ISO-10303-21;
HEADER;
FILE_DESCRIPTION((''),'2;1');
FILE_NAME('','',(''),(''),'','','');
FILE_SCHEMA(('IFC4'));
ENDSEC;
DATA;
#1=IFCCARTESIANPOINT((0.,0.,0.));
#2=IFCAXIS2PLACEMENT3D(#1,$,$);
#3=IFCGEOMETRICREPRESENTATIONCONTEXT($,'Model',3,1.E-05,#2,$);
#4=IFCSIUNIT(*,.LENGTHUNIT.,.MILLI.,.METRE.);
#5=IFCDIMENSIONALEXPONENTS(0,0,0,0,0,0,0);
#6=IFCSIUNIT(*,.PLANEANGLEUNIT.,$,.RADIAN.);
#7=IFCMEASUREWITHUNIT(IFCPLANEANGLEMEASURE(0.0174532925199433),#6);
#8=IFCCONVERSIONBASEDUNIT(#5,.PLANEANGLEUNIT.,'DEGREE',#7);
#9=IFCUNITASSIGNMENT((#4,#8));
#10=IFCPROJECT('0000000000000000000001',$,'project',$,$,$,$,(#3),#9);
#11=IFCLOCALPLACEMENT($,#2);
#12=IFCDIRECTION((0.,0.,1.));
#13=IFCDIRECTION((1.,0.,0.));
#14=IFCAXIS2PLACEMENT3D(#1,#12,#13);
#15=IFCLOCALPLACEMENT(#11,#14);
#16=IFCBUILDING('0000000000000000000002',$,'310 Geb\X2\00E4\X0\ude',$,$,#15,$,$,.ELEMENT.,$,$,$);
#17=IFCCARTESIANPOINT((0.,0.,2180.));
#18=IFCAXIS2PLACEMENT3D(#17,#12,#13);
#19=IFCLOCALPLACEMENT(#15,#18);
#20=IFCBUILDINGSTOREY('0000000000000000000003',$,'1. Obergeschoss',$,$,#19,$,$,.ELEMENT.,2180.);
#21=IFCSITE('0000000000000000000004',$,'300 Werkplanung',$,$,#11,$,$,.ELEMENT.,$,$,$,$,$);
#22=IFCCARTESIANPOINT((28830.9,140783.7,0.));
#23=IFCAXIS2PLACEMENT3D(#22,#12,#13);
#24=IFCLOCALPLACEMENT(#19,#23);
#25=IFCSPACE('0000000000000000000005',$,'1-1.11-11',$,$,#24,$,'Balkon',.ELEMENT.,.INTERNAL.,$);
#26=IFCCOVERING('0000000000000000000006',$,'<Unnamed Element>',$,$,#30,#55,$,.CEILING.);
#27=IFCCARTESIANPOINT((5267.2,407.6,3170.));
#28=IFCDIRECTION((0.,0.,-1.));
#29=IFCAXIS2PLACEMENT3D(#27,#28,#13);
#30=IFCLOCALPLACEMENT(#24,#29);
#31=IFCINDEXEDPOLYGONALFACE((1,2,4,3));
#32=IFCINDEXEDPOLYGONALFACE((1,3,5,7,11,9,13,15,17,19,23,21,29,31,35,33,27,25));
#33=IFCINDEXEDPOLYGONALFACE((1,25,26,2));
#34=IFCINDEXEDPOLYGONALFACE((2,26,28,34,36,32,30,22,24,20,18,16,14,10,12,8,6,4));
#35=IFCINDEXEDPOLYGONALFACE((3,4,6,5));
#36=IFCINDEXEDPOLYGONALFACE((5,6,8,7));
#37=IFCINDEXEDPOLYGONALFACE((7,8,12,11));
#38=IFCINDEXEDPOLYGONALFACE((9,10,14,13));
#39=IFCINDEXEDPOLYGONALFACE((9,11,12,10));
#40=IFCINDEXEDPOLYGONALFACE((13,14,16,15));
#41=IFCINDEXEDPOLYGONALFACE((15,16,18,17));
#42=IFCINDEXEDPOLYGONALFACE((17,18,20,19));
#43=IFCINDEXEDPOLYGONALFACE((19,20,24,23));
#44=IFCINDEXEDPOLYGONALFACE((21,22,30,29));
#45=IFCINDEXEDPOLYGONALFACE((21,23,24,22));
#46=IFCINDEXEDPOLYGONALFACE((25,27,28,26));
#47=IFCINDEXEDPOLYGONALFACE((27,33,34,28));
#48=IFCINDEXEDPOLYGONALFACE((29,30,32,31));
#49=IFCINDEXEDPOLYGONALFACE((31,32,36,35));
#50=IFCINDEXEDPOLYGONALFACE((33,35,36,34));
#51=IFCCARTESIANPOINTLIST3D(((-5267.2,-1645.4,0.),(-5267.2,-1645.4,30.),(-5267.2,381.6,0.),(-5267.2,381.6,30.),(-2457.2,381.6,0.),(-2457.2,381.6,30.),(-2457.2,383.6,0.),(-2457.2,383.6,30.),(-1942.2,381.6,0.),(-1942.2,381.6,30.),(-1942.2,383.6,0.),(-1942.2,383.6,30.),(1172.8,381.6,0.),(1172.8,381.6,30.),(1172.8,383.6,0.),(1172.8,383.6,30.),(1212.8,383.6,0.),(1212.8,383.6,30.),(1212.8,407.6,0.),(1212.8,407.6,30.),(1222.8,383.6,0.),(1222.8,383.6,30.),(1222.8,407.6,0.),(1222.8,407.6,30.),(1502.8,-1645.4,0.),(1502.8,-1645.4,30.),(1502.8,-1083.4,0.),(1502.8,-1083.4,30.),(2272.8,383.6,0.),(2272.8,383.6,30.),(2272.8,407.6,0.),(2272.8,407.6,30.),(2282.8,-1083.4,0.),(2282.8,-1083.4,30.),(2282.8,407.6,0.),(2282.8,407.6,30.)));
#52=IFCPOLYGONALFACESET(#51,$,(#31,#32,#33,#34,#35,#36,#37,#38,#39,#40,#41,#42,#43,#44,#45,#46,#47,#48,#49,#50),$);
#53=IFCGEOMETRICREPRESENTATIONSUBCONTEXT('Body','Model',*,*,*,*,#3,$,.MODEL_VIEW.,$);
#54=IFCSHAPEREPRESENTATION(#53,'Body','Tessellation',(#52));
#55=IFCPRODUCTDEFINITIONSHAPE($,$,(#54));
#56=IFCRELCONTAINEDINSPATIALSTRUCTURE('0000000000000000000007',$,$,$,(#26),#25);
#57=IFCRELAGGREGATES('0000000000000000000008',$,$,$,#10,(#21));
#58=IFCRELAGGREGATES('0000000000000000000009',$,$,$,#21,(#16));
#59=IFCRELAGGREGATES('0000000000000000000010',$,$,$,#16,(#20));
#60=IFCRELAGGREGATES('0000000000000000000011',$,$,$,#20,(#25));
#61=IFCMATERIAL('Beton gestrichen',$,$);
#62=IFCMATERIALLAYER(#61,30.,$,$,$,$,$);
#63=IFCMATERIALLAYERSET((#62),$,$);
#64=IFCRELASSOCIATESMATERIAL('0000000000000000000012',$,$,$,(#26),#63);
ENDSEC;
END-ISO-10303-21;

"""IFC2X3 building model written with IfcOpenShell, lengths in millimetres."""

from ifc_helpers import new_model, entity, si_unit, converted_unit, frame, origin, origin_with_axes, place, context, subcontext, project, spatial, polyline, outline, extrude, material, layer, layer_set, layer_usage, element, save


model = new_model("IFC2X3")

# Units and contexts
model_context = context("Model", 3, precision=1e-05, world=origin())
body_context = subcontext(model_context, "Body", "Model", "MODEL_VIEW")
ifc_project = project(units=[si_unit("LENGTHUNIT", "METRE", prefix="MILLI"), converted_unit("PLANEANGLEUNIT", "DEGREE", entity("IfcPlaneAngleMeasure", 0.0174532925199433), si_unit("PLANEANGLEUNIT", "RADIAN"), dimensions=[0, 0, 0, 0, 0, 0, 0])], contexts=[model_context])

# Site, building, storey
site_placement = place(None, origin())
site = spatial("IfcSite", under=ifc_project, at=site_placement, Name="300 Werkplanung", CompositionType="ELEMENT")
building_placement = place(site_placement, origin_with_axes())
building = spatial("IfcBuilding", under=site, at=building_placement, Name="310 Gebäude", CompositionType="ELEMENT")
storey_placement = place(building_placement, frame((0.0, 0.0, 2180.0), z_axis=(0.0, 0.0, 1.0), x_axis=(1.0, 0.0, 0.0)))
storey = spatial("IfcBuildingStorey", under=building, at=storey_placement, Name="1. Obergeschoss", CompositionType="ELEMENT", Elevation=2180.0)

# Shared definitions
space_1_placement = place(storey_placement, frame((28830.9, 140783.7, 0.0), z_axis=(0.0, 0.0, 1.0), x_axis=(1.0, 0.0, 0.0)))
space_1 = spatial("IfcSpace", under=storey, at=space_1_placement, Name="1-1.11-11", LongName="Balkon", CompositionType="ELEMENT", InteriorOrExteriorSpace="INTERNAL")

# Covering
ifc_material_1 = material(Name="Beton gestrichen")
ifc_layer_1 = layer(ifc_material_1, 30.0)
ifc_layer_set_1 = layer_set([ifc_layer_1])
ifc_layer_usage_1 = layer_usage(ifc_layer_set_1, "AXIS3", "POSITIVE", 0.0)
covering_1_placement = place(space_1_placement, frame((5267.2, 407.6, 3170.0), z_axis=(0.0, 0.0, -1.0), x_axis=(1.0, 0.0, 0.0)))
element("IfcCovering", 1, at=covering_1_placement, inside=space_1, material=ifc_layer_usage_1, Name="<Unnamed Element>", PredefinedType="CEILING", context=body_context, shape_type="SweptSolid", body=[
    extrude(outline(polyline([(1222.8, 407.6), (1212.8, 407.6), (1212.8, 383.6), (1172.8, 383.6), (1172.8, 381.6), (-1942.2, 381.6), (-1942.2, 383.6), (-2457.2, 383.6), (-2457.2, 381.6), (-5267.2, 381.6), (-5267.2, -1645.4), (1502.8, -1645.4), (1502.8, -1083.4), (2282.8, -1083.4), (2282.8, 407.6), (2272.8, 407.6), (2272.8, 383.6), (1222.8, 383.6), (1222.8, 407.6)])), origin_with_axes(), (0.0, 0.0, 1.0), 30.0),
])

save(model, "model.ifc")
